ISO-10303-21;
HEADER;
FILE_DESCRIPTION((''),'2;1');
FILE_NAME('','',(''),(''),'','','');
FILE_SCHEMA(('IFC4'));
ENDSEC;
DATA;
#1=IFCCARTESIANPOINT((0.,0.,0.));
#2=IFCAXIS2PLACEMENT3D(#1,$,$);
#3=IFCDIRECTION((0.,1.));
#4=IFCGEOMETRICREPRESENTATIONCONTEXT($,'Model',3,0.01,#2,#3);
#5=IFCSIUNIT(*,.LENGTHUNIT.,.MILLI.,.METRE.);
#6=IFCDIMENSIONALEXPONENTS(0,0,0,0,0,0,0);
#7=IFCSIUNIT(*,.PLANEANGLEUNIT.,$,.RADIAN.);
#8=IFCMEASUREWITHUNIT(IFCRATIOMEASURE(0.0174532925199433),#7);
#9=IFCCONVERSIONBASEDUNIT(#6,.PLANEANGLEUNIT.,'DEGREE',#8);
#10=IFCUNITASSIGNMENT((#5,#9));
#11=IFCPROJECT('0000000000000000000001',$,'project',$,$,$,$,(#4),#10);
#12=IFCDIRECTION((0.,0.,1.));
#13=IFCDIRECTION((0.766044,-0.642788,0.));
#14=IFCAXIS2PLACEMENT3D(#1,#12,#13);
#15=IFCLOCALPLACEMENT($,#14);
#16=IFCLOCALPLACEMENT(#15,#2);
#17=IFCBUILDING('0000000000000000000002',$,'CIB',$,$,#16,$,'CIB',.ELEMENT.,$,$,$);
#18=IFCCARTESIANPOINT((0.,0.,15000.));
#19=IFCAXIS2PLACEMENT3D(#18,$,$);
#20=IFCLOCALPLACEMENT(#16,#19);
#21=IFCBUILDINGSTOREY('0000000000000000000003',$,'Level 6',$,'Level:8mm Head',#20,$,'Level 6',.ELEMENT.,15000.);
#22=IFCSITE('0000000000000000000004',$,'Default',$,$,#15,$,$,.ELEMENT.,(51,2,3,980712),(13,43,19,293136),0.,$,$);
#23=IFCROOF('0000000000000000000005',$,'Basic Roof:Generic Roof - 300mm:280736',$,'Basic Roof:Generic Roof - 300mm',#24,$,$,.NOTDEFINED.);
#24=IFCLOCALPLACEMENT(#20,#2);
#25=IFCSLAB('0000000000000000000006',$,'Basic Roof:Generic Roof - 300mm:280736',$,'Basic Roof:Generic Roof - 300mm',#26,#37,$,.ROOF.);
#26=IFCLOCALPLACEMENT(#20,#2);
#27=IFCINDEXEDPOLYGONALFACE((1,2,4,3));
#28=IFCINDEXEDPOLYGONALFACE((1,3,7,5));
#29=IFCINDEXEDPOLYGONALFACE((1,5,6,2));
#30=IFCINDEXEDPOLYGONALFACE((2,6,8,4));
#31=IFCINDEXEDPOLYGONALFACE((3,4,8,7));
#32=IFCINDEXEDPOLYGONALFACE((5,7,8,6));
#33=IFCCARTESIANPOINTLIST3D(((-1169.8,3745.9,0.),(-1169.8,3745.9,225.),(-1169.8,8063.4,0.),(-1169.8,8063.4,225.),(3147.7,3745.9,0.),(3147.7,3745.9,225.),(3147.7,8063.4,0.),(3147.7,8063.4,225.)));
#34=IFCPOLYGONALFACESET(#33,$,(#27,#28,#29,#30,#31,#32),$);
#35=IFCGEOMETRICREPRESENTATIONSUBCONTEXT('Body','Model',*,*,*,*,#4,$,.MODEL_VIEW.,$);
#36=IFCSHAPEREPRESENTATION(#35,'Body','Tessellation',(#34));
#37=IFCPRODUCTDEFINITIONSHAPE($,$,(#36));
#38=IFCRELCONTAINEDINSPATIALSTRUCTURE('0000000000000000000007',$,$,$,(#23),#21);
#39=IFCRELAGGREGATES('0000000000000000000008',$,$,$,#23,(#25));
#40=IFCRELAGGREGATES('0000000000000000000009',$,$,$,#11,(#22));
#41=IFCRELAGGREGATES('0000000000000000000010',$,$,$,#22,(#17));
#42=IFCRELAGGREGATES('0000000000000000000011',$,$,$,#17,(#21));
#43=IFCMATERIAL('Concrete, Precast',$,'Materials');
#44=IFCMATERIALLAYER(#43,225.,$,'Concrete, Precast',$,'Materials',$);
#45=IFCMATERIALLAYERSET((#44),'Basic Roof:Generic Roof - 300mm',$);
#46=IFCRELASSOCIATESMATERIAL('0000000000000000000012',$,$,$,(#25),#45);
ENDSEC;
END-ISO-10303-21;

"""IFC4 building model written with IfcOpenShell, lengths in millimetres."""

from ifc_helpers import new_model, entity, si_unit, converted_unit, direction, frame, frame_2d, origin, place, context, subcontext, project, spatial, rectangle, extrude, material, layer, layer_set, element, aggregate, save


model = new_model("IFC4")

# Units and contexts
model_context = context("Model", 3, precision=0.01, world=origin(), true_north=direction((0.0, 1.0)))
body_context = subcontext(model_context, "Body", "Model", "MODEL_VIEW")
ifc_project = project(units=[si_unit("LENGTHUNIT", "METRE", prefix="MILLI"), converted_unit("PLANEANGLEUNIT", "DEGREE", entity("IfcRatioMeasure", 0.0174532925199433), si_unit("PLANEANGLEUNIT", "RADIAN"), dimensions=[0, 0, 0, 0, 0, 0, 0])], contexts=[model_context])

# Site, building, storey
site_placement = place(None, frame((0.0, 0.0, 0.0), z_axis=(0.0, 0.0, 1.0), x_axis=(0.766044, -0.642788, 0.0)))
site = spatial("IfcSite", under=ifc_project, at=site_placement, Name="Default", CompositionType="ELEMENT", RefLatitude=(51, 2, 3, 980712), RefLongitude=(13, 43, 19, 293136), RefElevation=0.0)
building_placement = place(site_placement, origin())
building = spatial("IfcBuilding", under=site, at=building_placement, Name="CIB", LongName="CIB", CompositionType="ELEMENT")
storey_placement = place(building_placement, frame((0.0, 0.0, 15000.0)))
storey = spatial("IfcBuildingStorey", under=building, at=storey_placement, Name="Level 6", ObjectType="Level:8mm Head", LongName="Level 6", CompositionType="ELEMENT", Elevation=15000.0)

# Roof, slab
roof_placement = place(storey_placement, frame((-1169.8, 3745.9, 0.0)))
roof = element("IfcRoof", 1, at=roof_placement, inside=storey, Name="Basic Roof:Generic Roof - 300mm:280736", ObjectType="Basic Roof:Generic Roof - 300mm", PredefinedType="NOTDEFINED")
ifc_material = material(Name="Concrete, Precast", Category="Materials")
ifc_layer = layer(ifc_material, 225.0, Name="Concrete, Precast", Category="Materials")
ifc_layer_set = layer_set([ifc_layer], Name="Basic Roof:Generic Roof - 300mm")
slab_placement = place(roof_placement, origin())
slab = element("IfcSlab", 2, at=slab_placement, material=ifc_layer_set, Name="Basic Roof:Generic Roof - 300mm:280736", ObjectType="Basic Roof:Generic Roof - 300mm", PredefinedType="ROOF", context=body_context, shape_type="SweptSolid", body=[
    extrude(rectangle(XDim=4317.5, YDim=4317.5, at=frame_2d((0.0, 0.0), x_axis=(0.0, 1.0))), frame((2158.8, 2158.8, 0.0)), (0.0, 0.0, 1.0), 225.0),
])
aggregate(roof, [slab])

save(model, "model.ifc")
